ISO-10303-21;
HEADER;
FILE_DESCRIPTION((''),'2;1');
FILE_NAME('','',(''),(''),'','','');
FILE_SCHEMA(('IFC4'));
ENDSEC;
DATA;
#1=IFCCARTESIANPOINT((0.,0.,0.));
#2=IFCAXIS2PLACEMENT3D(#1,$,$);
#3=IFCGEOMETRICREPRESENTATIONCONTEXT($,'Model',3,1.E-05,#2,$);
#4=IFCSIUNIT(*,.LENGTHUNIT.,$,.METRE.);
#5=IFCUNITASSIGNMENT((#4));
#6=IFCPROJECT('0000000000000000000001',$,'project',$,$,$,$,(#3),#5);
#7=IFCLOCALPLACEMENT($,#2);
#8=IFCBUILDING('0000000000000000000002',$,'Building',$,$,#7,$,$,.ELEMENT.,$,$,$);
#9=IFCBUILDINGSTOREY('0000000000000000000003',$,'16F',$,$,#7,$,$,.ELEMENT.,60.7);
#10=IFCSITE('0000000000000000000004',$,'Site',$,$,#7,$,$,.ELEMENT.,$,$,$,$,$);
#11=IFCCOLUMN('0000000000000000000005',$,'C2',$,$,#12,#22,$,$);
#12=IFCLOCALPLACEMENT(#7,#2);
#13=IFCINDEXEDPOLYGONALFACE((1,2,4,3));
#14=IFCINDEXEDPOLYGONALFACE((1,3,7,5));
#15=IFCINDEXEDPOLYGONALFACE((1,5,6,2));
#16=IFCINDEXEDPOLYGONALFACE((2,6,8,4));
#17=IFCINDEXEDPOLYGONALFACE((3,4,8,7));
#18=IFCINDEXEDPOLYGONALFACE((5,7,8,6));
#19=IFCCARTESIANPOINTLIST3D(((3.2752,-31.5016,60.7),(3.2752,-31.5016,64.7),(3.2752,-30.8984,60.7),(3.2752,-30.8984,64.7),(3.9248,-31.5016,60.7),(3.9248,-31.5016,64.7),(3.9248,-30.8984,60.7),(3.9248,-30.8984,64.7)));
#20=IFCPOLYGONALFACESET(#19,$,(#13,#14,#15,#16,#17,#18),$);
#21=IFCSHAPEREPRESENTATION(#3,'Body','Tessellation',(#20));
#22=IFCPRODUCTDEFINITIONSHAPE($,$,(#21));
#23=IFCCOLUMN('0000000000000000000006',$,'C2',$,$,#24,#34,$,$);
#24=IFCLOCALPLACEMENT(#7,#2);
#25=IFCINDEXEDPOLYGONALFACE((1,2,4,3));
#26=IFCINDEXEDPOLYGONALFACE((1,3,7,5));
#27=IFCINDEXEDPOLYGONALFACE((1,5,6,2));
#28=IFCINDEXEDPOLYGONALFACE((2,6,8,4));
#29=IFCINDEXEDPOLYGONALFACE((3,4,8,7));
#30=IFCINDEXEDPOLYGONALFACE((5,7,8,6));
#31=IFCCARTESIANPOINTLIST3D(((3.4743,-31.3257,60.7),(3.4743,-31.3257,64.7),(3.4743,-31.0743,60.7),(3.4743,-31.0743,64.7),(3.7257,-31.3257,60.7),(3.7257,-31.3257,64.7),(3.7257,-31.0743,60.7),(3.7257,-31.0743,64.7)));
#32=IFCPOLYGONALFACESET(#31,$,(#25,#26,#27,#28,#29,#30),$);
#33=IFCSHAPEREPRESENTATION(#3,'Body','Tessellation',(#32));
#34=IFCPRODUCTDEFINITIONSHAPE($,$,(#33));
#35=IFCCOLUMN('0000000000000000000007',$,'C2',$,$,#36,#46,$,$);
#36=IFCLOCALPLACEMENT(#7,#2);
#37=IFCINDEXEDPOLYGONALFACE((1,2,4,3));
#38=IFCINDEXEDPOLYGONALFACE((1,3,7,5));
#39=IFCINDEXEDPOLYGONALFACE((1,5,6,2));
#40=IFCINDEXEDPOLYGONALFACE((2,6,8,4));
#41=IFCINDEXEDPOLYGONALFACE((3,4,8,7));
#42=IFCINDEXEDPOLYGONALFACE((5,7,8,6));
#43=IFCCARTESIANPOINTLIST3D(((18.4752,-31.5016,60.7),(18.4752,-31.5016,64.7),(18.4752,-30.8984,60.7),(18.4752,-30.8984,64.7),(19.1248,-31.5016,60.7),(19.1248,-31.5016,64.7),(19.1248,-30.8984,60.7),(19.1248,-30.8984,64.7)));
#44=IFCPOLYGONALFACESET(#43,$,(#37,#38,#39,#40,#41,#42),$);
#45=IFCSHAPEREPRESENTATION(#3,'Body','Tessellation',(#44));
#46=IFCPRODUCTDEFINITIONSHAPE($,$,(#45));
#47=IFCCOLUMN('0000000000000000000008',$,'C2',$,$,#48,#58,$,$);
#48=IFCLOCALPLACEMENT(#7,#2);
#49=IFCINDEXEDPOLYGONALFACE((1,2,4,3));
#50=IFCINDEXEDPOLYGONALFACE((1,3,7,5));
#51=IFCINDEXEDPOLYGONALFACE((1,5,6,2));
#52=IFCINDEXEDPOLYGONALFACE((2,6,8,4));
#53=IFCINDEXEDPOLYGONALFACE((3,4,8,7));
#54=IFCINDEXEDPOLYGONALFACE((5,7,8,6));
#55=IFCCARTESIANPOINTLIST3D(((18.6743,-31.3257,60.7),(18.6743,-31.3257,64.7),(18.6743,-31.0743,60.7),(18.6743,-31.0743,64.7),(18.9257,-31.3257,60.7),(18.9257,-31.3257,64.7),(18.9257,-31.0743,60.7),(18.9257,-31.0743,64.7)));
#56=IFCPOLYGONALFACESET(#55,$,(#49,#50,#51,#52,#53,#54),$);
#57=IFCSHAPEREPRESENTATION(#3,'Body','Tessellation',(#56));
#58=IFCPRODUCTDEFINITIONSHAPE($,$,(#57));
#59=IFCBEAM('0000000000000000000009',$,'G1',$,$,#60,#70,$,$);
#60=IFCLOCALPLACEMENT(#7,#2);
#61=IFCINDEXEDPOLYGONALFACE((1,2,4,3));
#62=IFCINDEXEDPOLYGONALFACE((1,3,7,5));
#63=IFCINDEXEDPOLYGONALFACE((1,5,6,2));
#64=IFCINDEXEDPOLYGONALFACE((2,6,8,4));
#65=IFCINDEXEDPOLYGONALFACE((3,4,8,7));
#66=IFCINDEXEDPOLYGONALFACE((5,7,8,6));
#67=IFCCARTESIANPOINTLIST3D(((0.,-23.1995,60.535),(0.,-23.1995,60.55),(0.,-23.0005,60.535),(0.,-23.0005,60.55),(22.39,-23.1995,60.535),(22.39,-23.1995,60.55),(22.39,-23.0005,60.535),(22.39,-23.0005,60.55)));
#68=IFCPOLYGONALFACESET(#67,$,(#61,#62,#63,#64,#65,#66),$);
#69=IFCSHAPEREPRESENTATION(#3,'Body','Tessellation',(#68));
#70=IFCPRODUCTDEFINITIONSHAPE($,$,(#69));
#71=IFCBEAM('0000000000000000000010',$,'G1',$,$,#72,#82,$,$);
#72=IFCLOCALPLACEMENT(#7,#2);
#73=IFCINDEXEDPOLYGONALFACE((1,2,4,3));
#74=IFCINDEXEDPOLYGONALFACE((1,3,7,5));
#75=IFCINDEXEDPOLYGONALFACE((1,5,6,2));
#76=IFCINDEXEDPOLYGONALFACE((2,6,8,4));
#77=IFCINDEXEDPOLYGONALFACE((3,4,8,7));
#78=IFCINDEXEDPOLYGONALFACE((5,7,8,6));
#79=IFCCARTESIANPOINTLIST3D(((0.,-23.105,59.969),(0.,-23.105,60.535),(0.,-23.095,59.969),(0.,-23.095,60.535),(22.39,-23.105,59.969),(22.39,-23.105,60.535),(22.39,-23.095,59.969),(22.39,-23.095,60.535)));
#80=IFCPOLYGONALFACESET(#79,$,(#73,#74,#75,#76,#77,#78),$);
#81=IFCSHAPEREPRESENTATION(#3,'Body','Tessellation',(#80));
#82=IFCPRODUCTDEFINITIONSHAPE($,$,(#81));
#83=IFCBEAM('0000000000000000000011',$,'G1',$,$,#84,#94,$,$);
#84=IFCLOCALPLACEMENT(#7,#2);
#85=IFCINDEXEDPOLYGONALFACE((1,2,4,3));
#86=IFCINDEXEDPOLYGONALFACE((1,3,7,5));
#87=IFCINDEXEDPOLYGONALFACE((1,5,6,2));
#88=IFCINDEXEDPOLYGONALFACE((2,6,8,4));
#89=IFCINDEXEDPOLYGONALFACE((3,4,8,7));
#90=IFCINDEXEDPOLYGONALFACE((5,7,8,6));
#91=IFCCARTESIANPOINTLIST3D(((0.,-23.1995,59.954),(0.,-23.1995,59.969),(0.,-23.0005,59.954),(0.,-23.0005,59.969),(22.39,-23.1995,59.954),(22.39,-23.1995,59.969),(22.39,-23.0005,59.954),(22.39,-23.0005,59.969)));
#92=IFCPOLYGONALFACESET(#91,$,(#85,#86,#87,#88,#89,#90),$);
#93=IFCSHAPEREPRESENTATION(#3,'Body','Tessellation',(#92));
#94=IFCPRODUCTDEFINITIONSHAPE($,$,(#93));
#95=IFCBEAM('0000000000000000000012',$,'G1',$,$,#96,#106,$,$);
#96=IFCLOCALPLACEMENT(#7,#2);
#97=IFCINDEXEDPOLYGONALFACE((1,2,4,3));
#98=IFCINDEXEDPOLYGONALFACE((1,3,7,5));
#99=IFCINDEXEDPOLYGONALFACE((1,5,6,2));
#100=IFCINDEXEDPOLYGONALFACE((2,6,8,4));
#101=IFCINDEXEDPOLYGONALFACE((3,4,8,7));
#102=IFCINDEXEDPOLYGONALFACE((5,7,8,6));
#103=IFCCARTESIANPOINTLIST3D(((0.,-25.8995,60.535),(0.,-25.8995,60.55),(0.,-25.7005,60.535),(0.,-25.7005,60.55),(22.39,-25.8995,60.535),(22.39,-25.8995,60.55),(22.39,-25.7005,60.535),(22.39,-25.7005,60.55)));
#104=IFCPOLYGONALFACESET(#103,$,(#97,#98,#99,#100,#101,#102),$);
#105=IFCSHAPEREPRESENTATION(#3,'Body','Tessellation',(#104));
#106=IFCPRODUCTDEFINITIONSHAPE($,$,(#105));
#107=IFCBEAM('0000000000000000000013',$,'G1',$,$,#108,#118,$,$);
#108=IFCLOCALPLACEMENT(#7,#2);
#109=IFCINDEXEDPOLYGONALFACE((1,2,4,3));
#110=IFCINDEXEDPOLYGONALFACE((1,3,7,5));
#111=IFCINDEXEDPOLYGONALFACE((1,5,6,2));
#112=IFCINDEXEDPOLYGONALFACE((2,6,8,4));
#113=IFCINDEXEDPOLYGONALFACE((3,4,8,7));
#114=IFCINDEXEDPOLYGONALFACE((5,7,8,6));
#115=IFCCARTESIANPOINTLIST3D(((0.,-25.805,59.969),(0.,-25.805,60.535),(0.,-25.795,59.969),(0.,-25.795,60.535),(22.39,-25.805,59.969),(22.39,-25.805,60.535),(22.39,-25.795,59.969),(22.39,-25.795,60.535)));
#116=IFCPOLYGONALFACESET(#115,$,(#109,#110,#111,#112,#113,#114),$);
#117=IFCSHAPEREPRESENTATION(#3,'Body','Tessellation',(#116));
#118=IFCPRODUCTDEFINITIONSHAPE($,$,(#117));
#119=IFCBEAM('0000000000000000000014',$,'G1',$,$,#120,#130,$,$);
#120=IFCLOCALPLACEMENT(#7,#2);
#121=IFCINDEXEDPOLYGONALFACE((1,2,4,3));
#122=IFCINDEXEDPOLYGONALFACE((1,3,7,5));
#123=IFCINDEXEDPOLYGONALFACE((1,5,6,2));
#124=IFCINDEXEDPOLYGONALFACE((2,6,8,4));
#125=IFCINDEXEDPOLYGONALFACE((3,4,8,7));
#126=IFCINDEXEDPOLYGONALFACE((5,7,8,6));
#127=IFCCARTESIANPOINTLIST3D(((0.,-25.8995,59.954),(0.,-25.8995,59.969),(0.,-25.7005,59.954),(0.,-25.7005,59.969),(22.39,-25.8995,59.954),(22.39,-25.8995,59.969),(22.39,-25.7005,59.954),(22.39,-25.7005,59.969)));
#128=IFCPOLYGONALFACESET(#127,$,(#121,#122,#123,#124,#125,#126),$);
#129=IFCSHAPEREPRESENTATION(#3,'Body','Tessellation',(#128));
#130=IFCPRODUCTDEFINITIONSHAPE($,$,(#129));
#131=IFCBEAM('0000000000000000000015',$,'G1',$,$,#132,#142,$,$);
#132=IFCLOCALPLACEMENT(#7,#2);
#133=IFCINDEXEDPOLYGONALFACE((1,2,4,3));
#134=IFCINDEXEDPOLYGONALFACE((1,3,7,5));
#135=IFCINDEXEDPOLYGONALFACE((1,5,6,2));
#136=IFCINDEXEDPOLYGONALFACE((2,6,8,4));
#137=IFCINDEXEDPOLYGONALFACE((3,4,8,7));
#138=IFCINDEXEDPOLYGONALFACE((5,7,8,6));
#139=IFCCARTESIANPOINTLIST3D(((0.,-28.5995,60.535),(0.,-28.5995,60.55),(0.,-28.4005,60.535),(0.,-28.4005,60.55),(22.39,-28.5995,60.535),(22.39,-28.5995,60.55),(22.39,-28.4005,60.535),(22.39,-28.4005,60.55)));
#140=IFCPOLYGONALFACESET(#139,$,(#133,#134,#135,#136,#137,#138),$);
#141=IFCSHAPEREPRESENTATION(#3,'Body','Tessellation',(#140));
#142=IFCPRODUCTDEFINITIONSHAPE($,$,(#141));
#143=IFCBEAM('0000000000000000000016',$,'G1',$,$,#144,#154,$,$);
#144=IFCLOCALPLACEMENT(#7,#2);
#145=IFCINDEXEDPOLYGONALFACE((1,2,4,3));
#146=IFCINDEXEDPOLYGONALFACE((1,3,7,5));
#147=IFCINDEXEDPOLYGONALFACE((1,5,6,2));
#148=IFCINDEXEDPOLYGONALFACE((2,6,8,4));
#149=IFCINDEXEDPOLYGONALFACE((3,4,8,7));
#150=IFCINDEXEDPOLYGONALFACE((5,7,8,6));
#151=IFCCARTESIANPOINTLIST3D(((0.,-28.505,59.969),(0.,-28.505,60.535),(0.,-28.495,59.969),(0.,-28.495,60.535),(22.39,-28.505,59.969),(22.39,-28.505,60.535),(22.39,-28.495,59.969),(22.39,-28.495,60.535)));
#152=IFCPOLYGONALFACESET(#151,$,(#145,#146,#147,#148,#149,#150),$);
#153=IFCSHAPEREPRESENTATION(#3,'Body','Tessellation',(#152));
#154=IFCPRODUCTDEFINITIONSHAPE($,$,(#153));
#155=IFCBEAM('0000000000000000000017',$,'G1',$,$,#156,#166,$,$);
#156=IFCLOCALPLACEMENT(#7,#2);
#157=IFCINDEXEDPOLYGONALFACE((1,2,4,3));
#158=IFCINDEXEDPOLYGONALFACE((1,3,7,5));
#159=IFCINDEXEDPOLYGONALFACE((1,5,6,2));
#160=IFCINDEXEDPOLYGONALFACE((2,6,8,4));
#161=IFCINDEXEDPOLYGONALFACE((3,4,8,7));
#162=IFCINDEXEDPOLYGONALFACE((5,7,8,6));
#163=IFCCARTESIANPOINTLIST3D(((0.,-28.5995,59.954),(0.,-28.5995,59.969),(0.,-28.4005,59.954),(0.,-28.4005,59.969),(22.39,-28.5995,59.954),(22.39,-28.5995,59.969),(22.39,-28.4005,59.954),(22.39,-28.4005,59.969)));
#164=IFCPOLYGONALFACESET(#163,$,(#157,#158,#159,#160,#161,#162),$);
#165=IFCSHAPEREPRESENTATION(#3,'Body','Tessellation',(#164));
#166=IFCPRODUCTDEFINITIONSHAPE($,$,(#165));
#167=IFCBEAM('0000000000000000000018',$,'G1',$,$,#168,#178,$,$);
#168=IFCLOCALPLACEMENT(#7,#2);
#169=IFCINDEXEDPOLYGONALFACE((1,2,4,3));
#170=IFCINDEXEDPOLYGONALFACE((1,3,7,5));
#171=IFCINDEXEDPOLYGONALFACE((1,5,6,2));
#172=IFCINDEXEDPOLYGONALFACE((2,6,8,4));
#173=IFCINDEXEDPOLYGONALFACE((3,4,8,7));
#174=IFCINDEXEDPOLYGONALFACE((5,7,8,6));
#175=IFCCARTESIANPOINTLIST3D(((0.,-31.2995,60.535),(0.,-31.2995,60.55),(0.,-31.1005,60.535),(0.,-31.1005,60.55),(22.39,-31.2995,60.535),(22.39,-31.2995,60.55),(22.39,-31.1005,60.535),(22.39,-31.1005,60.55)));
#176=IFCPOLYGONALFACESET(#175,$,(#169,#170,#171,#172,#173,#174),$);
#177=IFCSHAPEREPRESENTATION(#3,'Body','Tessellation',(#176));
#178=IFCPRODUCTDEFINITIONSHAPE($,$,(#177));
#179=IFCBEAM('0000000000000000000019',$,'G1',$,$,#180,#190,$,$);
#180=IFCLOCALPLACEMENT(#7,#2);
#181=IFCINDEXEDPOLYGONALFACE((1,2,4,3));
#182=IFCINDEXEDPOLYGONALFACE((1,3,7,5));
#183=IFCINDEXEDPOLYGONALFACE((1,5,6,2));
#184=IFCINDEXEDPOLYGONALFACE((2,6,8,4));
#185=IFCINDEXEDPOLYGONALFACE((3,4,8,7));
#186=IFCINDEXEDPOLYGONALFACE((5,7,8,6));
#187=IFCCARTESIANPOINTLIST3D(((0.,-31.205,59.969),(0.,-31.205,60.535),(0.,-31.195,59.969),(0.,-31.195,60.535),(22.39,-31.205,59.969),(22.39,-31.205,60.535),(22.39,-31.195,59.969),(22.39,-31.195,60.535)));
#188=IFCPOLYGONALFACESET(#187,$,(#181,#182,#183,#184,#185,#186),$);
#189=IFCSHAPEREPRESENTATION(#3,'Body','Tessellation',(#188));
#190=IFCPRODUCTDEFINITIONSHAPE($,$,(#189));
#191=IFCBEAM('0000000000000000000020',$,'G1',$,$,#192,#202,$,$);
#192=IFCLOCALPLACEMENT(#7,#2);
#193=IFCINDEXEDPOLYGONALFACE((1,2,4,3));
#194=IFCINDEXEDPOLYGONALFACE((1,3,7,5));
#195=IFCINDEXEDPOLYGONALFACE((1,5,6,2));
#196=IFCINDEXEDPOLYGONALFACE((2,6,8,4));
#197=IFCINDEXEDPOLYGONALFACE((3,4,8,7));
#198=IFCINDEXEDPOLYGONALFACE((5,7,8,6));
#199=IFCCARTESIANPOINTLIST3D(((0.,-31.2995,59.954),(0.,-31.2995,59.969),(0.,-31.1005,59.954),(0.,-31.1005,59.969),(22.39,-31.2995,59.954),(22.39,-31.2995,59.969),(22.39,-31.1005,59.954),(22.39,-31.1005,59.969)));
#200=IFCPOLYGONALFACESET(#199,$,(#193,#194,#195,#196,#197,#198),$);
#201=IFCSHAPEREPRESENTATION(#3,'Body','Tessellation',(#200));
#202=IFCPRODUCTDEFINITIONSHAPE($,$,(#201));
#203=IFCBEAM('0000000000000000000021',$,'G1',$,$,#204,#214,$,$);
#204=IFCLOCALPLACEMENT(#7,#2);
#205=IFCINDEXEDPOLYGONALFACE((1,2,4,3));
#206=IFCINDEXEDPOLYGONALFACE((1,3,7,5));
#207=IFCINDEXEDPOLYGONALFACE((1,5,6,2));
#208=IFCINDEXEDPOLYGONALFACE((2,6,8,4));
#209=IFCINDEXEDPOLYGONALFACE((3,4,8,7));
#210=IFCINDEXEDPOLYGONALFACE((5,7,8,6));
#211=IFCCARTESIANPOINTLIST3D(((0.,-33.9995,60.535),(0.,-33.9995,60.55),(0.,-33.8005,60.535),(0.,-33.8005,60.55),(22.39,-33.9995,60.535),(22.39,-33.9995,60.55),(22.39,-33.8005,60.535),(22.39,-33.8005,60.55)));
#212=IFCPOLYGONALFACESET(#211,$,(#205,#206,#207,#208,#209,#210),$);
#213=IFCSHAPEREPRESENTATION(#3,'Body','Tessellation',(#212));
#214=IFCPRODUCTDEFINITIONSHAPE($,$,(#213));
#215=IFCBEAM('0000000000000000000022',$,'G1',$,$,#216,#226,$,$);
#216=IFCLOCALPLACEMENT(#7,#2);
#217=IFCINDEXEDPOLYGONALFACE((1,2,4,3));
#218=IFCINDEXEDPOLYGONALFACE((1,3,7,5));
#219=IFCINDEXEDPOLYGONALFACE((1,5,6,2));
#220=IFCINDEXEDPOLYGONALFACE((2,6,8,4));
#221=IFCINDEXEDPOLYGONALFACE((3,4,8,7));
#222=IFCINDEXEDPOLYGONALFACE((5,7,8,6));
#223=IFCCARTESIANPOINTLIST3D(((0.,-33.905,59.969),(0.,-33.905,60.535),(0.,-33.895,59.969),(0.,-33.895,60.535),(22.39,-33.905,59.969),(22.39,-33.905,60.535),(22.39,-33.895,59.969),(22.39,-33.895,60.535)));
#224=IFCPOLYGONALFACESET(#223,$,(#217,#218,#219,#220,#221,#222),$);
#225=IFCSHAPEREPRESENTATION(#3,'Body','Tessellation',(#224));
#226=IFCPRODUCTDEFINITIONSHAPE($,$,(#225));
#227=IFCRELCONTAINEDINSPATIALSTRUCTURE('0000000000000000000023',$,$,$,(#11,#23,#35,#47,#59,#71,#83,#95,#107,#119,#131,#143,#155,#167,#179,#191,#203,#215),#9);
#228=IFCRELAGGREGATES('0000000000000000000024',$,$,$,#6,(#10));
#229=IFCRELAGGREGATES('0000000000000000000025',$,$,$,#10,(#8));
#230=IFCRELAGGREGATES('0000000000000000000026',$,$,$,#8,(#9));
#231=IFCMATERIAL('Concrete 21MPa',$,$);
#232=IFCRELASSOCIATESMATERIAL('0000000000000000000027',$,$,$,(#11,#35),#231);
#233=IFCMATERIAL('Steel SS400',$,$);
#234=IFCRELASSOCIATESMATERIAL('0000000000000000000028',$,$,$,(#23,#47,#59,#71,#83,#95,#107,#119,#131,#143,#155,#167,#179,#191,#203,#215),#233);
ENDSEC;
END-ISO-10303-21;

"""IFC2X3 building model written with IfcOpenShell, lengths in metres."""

from ifc_helpers import new_model, si_unit, frame, origin, origin_2d, place, context, project, spatial, rectangle, extrude, material, element, save


model = new_model("IFC2X3")

# Units and contexts
model_context = context("Model", 3, precision=1e-05, world=origin())
ifc_project = project(units=[si_unit("LENGTHUNIT", "METRE")], contexts=[model_context])

# Site, building, storey
placement = place(None, origin())
site = spatial("IfcSite", under=ifc_project, at=placement, Name="Site", CompositionType="ELEMENT")
building = spatial("IfcBuilding", under=site, at=placement, Name="Building", CompositionType="ELEMENT")
storey = spatial("IfcBuildingStorey", under=building, at=placement, Name="16F", CompositionType="ELEMENT", Elevation=60.7)

# Columns
ifc_material_1 = material(Name="Concrete 21MPa")
column_1_placement = place(None, frame((3.6, -31.2, 60.7)))
element("IfcColumn", 1, at=column_1_placement, inside=storey, material=ifc_material_1, Name="C2", context=model_context, shape_type="SweptSolid", body=[
    extrude(rectangle(XDim=0.6496, YDim=0.6032, at=origin_2d()), origin(), (0.0, 0.0, 1.0), 4.0),
])
ifc_material_2 = material(Name="Steel SS400")
column_2_placement = place(None, frame((3.6, -31.2, 60.7)))
element("IfcColumn", 2, at=column_2_placement, inside=storey, material=ifc_material_2, Name="C2", context=model_context, shape_type="SweptSolid", body=[
    extrude(rectangle(XDim=0.2513, YDim=0.2513, at=origin_2d()), origin(), (0.0, 0.0, 1.0), 4.0),
])
column_3_placement = place(None, frame((18.8, -31.2, 60.7)))
element("IfcColumn", 3, at=column_3_placement, inside=storey, material=ifc_material_1, Name="C2", context=model_context, shape_type="SweptSolid", body=[
    extrude(rectangle(XDim=0.6496, YDim=0.6032, at=origin_2d()), origin(), (0.0, 0.0, 1.0), 4.0),
])
column_4_placement = place(None, frame((18.8, -31.2, 60.7)))
element("IfcColumn", 4, at=column_4_placement, inside=storey, material=ifc_material_2, Name="C2", context=model_context, shape_type="SweptSolid", body=[
    extrude(rectangle(XDim=0.2513, YDim=0.2513, at=origin_2d()), origin(), (0.0, 0.0, 1.0), 4.0),
])

# Beams
beam_1_placement = place(None, frame((11.195, -23.1, 60.535)))
element("IfcBeam", 5, at=beam_1_placement, inside=storey, material=ifc_material_2, Name="G1", context=model_context, shape_type="SweptSolid", body=[
    extrude(rectangle(XDim=22.39, YDim=0.199, at=origin_2d()), origin(), (0.0, 0.0, 1.0), 0.015),
])
beam_2_placement = place(None, frame((11.195, -23.1, 59.969)))
element("IfcBeam", 6, at=beam_2_placement, inside=storey, material=ifc_material_2, Name="G1", context=model_context, shape_type="SweptSolid", body=[
    extrude(rectangle(XDim=22.39, YDim=0.01, at=origin_2d()), origin(), (0.0, 0.0, 1.0), 0.566),
])
for number, where, name in (
    (7, (11.195, -23.1, 59.954), "G1"),
    (8, (11.195, -25.8, 60.535), "G1"),
):
    element("IfcBeam", number, at=place(None, frame(where)), inside=storey, material=ifc_material_2, Name=name, context=model_context, shape_type="SweptSolid", body=[
        extrude(rectangle(XDim=22.39, YDim=0.199, at=origin_2d()), origin(), (0.0, 0.0, 1.0), 0.015),
    ])
beam_3_placement = place(None, frame((11.195, -25.8, 59.969)))
element("IfcBeam", 9, at=beam_3_placement, inside=storey, material=ifc_material_2, Name="G1", context=model_context, shape_type="SweptSolid", body=[
    extrude(rectangle(XDim=22.39, YDim=0.01, at=origin_2d()), origin(), (0.0, 0.0, 1.0), 0.566),
])
for number, where, name in (
    (10, (11.195, -25.8, 59.954), "G1"),
    (11, (11.195, -28.5, 60.535), "G1"),
):
    element("IfcBeam", number, at=place(None, frame(where)), inside=storey, material=ifc_material_2, Name=name, context=model_context, shape_type="SweptSolid", body=[
        extrude(rectangle(XDim=22.39, YDim=0.199, at=origin_2d()), origin(), (0.0, 0.0, 1.0), 0.015),
    ])
beam_4_placement = place(None, frame((11.195, -28.5, 59.969)))
element("IfcBeam", 12, at=beam_4_placement, inside=storey, material=ifc_material_2, Name="G1", context=model_context, shape_type="SweptSolid", body=[
    extrude(rectangle(XDim=22.39, YDim=0.01, at=origin_2d()), origin(), (0.0, 0.0, 1.0), 0.566),
])
for number, where, name in (
    (13, (11.195, -28.5, 59.954), "G1"),
    (14, (11.195, -31.2, 60.535), "G1"),
):
    element("IfcBeam", number, at=place(None, frame(where)), inside=storey, material=ifc_material_2, Name=name, context=model_context, shape_type="SweptSolid", body=[
        extrude(rectangle(XDim=22.39, YDim=0.199, at=origin_2d()), origin(), (0.0, 0.0, 1.0), 0.015),
    ])
beam_5_placement = place(None, frame((11.195, -31.2, 59.969)))
element("IfcBeam", 15, at=beam_5_placement, inside=storey, material=ifc_material_2, Name="G1", context=model_context, shape_type="SweptSolid", body=[
    extrude(rectangle(XDim=22.39, YDim=0.01, at=origin_2d()), origin(), (0.0, 0.0, 1.0), 0.566),
])
for number, where, name in (
    (16, (11.195, -31.2, 59.954), "G1"),
    (17, (11.195, -33.9, 60.535), "G1"),
):
    element("IfcBeam", number, at=place(None, frame(where)), inside=storey, material=ifc_material_2, Name=name, context=model_context, shape_type="SweptSolid", body=[
        extrude(rectangle(XDim=22.39, YDim=0.199, at=origin_2d()), origin(), (0.0, 0.0, 1.0), 0.015),
    ])
beam_6_placement = place(None, frame((11.195, -33.9, 59.969)))
element("IfcBeam", 18, at=beam_6_placement, inside=storey, material=ifc_material_2, Name="G1", context=model_context, shape_type="SweptSolid", body=[
    extrude(rectangle(XDim=22.39, YDim=0.01, at=origin_2d()), origin(), (0.0, 0.0, 1.0), 0.566),
])

save(model, "model.ifc")
